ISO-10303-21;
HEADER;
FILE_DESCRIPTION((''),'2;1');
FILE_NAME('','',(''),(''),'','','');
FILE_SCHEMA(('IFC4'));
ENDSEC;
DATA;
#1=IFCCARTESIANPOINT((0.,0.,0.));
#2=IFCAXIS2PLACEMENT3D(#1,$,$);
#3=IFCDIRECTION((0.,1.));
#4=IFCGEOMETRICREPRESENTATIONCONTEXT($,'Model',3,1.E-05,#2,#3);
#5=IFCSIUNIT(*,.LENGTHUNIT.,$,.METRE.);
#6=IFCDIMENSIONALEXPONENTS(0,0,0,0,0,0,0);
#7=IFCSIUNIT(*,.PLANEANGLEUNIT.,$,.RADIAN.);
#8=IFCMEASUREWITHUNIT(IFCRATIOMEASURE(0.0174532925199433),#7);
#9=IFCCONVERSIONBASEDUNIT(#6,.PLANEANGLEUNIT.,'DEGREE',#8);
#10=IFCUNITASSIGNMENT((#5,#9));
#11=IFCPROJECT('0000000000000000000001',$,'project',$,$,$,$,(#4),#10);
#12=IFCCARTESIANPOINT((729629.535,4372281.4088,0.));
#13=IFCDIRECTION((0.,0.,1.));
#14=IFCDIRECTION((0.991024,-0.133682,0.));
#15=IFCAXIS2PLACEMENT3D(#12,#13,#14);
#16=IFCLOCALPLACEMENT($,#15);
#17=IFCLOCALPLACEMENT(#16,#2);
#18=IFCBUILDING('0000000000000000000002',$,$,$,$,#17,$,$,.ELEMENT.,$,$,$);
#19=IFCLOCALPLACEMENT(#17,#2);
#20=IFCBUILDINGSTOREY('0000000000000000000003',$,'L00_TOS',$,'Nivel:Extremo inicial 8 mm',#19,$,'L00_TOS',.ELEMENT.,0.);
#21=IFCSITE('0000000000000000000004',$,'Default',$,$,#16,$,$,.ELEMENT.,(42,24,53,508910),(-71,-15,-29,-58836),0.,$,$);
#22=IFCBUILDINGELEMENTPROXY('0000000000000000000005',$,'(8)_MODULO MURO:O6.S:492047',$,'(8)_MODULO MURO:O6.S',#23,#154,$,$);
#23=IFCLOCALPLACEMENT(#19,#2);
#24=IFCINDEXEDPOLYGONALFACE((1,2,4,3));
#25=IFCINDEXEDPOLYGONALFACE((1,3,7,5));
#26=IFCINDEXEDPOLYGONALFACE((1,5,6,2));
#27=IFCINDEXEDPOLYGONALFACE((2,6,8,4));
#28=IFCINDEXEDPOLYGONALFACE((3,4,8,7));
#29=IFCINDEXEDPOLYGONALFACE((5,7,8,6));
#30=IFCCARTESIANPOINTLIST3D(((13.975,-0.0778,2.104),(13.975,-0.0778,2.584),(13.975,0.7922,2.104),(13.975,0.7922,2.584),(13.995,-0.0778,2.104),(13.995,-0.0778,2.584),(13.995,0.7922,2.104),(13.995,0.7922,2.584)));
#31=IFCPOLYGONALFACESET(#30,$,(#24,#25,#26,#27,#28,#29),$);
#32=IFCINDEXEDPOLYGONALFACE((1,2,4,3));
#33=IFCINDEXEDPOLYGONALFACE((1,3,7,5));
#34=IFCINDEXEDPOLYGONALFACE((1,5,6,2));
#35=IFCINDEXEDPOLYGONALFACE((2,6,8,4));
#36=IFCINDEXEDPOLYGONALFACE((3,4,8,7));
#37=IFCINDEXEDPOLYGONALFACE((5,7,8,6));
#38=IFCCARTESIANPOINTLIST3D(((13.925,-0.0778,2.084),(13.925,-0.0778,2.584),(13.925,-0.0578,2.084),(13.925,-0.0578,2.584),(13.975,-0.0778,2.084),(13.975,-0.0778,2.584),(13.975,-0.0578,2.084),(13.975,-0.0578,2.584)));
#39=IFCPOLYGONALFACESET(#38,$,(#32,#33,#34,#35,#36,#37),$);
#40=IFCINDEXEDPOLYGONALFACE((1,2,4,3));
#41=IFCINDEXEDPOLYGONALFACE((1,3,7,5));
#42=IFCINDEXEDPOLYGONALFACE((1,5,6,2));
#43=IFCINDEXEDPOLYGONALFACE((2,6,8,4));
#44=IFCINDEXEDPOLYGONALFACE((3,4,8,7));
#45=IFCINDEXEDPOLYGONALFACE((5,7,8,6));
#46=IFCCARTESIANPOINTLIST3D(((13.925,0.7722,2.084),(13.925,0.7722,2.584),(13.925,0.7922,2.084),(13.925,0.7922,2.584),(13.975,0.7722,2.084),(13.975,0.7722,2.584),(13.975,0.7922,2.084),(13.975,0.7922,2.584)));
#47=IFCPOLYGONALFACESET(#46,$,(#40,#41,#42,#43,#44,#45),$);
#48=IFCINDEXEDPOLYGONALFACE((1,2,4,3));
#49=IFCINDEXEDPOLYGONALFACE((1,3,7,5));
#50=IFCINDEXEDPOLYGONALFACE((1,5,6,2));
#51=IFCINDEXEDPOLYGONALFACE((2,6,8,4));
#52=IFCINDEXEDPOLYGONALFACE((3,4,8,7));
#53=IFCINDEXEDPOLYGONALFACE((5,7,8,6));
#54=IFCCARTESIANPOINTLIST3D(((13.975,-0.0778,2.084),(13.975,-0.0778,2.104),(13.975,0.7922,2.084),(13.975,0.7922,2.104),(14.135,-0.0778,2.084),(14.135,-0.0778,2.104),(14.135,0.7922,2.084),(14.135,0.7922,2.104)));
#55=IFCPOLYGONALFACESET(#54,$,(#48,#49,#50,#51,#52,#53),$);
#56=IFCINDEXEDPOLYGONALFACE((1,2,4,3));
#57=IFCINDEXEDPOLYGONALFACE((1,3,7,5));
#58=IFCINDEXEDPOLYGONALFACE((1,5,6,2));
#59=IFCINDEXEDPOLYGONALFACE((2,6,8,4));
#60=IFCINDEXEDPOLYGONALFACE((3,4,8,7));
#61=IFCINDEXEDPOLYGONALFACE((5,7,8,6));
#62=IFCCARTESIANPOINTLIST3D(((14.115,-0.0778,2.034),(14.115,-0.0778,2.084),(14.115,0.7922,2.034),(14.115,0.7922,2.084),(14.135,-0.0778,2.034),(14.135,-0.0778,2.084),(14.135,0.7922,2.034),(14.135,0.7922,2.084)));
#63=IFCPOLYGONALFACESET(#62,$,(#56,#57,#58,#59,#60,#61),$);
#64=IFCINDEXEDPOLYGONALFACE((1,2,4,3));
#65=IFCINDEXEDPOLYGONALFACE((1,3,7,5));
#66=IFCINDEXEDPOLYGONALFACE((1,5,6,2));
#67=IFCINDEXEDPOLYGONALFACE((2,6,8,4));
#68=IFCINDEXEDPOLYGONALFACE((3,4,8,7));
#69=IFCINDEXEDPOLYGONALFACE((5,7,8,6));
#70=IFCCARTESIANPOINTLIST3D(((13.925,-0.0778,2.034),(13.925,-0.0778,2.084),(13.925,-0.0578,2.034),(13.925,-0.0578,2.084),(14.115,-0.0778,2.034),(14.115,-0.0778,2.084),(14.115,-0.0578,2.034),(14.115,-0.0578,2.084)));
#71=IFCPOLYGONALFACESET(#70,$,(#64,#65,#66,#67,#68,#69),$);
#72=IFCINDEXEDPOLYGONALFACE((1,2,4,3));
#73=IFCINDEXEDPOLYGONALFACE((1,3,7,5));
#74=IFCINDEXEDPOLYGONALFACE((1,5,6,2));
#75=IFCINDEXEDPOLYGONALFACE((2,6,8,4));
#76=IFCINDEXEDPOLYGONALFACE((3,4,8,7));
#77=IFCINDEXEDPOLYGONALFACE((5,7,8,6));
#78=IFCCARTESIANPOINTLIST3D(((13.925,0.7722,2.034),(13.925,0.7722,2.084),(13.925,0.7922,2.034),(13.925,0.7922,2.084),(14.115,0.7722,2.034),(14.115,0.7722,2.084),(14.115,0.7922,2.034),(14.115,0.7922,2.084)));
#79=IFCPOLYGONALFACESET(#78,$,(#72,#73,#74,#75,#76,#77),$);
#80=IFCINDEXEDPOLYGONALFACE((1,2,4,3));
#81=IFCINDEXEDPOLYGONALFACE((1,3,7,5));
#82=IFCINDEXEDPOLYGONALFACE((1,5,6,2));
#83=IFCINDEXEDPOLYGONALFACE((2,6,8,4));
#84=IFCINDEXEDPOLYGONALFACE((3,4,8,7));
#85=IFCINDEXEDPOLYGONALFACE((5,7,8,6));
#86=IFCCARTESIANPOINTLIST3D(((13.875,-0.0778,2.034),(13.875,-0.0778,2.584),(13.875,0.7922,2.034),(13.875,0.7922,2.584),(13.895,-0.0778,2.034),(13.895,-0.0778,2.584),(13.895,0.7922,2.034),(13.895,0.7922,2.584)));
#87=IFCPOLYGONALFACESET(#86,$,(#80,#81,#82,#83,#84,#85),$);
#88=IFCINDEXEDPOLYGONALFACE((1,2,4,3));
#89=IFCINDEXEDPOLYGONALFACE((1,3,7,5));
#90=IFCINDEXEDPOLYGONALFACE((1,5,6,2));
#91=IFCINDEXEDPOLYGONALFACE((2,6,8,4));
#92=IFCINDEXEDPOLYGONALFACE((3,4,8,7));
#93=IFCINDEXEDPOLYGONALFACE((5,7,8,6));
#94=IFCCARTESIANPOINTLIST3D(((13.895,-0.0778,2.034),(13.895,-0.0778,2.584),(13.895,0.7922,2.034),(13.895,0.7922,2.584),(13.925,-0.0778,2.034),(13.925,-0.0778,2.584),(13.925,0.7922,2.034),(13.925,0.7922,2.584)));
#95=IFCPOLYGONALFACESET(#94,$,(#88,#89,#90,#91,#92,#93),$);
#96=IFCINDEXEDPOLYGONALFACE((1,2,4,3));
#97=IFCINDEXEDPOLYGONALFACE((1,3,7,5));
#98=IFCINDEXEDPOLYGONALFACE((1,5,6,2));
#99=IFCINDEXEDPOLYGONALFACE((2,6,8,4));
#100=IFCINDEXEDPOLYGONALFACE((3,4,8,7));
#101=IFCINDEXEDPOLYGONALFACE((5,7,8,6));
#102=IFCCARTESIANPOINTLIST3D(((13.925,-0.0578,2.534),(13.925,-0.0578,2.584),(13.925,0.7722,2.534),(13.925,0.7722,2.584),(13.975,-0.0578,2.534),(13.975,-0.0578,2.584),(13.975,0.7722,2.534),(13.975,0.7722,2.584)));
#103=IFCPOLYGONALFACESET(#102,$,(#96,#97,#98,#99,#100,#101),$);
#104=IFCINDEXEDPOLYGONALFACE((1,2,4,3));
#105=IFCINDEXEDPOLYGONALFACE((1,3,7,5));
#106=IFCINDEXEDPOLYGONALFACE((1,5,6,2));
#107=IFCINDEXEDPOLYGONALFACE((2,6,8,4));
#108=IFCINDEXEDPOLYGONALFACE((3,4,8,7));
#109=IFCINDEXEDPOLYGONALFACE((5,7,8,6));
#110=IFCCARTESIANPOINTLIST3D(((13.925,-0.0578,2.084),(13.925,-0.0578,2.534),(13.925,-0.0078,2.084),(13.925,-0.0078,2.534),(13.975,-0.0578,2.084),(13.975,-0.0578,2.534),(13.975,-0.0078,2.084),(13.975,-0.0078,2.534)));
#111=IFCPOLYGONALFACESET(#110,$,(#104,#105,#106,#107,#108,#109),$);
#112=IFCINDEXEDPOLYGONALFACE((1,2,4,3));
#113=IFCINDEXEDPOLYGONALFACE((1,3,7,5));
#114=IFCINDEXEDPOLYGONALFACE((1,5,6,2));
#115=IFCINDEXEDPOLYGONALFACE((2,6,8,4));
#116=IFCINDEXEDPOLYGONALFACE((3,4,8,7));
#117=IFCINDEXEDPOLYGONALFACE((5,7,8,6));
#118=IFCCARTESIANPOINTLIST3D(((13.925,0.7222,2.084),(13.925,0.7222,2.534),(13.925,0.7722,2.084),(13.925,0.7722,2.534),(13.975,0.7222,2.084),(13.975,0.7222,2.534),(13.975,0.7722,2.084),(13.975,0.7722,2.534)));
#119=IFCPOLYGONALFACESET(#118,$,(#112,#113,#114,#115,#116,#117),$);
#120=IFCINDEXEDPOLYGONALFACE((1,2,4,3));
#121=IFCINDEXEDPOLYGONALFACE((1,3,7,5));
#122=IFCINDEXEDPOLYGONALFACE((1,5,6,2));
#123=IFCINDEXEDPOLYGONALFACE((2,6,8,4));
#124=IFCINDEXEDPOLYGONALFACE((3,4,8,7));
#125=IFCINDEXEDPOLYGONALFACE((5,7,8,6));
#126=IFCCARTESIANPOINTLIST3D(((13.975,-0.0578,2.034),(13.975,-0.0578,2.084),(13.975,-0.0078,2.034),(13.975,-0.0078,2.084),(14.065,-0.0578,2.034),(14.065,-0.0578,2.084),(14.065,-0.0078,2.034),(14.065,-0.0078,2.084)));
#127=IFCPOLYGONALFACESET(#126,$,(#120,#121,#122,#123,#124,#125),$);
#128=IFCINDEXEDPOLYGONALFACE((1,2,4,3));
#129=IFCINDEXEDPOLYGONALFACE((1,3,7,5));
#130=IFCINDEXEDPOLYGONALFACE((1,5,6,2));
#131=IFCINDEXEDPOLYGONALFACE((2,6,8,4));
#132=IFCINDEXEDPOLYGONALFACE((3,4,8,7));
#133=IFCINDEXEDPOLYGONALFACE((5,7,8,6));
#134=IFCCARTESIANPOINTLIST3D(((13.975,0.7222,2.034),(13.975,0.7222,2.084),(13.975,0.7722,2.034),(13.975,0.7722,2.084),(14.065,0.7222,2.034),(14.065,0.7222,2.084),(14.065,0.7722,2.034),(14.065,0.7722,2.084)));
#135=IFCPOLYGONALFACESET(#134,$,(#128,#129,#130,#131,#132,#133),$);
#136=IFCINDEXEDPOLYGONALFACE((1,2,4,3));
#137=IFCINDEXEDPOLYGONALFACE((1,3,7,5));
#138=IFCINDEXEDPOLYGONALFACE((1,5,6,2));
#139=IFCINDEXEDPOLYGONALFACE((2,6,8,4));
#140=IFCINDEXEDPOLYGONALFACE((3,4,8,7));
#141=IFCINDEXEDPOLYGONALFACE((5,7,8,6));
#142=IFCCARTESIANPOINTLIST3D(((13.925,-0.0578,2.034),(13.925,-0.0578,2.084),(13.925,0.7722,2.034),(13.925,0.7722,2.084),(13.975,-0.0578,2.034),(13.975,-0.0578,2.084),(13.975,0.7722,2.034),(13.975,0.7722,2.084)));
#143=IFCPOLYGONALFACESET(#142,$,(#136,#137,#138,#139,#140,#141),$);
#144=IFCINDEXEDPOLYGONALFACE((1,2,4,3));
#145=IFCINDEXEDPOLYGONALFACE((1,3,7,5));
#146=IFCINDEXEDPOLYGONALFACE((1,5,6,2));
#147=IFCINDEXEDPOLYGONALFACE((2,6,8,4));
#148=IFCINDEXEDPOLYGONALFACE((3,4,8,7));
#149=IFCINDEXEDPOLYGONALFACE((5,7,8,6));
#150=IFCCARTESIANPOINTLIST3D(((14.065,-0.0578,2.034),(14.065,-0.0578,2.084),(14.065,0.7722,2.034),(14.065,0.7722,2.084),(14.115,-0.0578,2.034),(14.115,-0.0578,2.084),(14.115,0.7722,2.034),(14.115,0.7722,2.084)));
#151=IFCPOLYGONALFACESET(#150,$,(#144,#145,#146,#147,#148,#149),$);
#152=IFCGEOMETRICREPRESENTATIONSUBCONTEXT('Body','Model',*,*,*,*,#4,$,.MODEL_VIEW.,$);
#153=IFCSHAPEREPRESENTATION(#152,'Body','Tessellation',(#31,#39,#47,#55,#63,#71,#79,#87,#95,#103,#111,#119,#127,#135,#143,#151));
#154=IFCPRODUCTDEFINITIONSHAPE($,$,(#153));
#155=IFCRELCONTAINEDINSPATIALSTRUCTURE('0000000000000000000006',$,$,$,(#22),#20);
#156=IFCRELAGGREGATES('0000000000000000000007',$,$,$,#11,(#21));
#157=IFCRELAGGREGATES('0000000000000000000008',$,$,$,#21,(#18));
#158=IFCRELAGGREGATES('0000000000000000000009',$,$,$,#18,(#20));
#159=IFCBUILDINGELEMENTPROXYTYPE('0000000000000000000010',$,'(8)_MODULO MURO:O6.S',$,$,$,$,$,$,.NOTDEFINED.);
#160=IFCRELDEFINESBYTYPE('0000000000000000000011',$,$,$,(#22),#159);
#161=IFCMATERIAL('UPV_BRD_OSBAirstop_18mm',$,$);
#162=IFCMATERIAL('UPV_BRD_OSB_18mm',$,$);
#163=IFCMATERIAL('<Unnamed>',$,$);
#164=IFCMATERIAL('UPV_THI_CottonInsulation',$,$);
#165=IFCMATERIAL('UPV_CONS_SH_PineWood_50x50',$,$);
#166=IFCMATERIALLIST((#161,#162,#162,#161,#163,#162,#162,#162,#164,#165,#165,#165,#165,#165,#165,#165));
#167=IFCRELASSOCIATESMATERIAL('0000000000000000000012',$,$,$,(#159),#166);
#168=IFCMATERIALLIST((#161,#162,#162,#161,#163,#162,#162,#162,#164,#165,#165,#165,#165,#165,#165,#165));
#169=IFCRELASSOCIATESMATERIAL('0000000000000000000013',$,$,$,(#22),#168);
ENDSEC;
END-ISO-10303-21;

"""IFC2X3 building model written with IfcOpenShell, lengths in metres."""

from ifc_helpers import new_model, entity, si_unit, converted_unit, direction, frame, frame_2d, origin, origin_2d_with_axis, place, context, subcontext, project, spatial, rectangle, extrude, source, transform, mapped, material, material_list, type_object, type_shapes, element, save


model = new_model("IFC2X3")

# Units and contexts
model_context = context("Model", 3, precision=1e-05, world=origin(), true_north=direction((0.0, 1.0)))
body_context = subcontext(model_context, "Body", "Model", "MODEL_VIEW")
ifc_project = project(units=[si_unit("LENGTHUNIT", "METRE"), converted_unit("PLANEANGLEUNIT", "DEGREE", entity("IfcRatioMeasure", 0.0174532925199433), si_unit("PLANEANGLEUNIT", "RADIAN"), dimensions=[0, 0, 0, 0, 0, 0, 0])], contexts=[model_context])

# Site, building, storey
site_placement = place(None, frame((729629.535, 4372281.4088, 0.0), z_axis=(0.0, 0.0, 1.0), x_axis=(0.991024, -0.133682, 0.0)))
site = spatial("IfcSite", under=ifc_project, at=site_placement, Name="Default", CompositionType="ELEMENT", RefLatitude=(42, 24, 53, 508910), RefLongitude=(-71, -15, -29, -58836), RefElevation=0.0)
building_placement = place(site_placement, origin())
building = spatial("IfcBuilding", under=site, at=building_placement, CompositionType="ELEMENT")
storey_placement = place(building_placement, origin())
storey = spatial("IfcBuildingStorey", under=building, at=storey_placement, Name="L00_TOS", ObjectType="Nivel:Extremo inicial 8 mm", LongName="L00_TOS", CompositionType="ELEMENT", Elevation=0.0)

# Building element proxy
ifc_material_1 = material(Name="UPV_BRD_OSBAirstop_18mm")
ifc_material_2 = material(Name="UPV_BRD_OSB_18mm")
ifc_material_3 = material(Name="UPV_THI_CottonInsulation")
ifc_material_4 = material(Name="<Unnamed>")
ifc_material_5 = material(Name="UPV_CONS_SH_PineWood_50x50")
ifc_material_list_1 = material_list([ifc_material_1, ifc_material_2, ifc_material_2, ifc_material_1, ifc_material_4, ifc_material_2, ifc_material_2, ifc_material_2, ifc_material_3, ifc_material_5, ifc_material_5, ifc_material_5, ifc_material_5, ifc_material_5, ifc_material_5, ifc_material_5])
ifc_material_list_2 = material_list([ifc_material_1, ifc_material_2, ifc_material_2, ifc_material_1, ifc_material_4, ifc_material_2, ifc_material_2, ifc_material_2, ifc_material_3, ifc_material_5, ifc_material_5, ifc_material_5, ifc_material_5, ifc_material_5, ifc_material_5, ifc_material_5])
building_element_proxy_type_1 = type_object("IfcBuildingElementProxyType", Name="(8)_MODULO MURO:O6.S", PredefinedType="NOTDEFINED", material=ifc_material_list_2)
shared_shape_1 = source(origin(), body_context, "Body", "SweptSolid", [
    extrude(rectangle(XDim=0.87, YDim=0.02, at=frame_2d((0.0, 0.0), x_axis=(1.0, 0.0))), frame((0.0, 0.035, 0.07), z_axis=(0.0, 0.0, 1.0), x_axis=(-1.0, 0.0, 0.0)), (0.0, 0.0, 1.0), 0.48),
    extrude(rectangle(XDim=0.05, YDim=0.02, at=frame_2d((0.0, 0.0), x_axis=(1.0, 0.0))), frame((-0.425, 0.07, 0.05), z_axis=(0.0, 0.0, 1.0), x_axis=(0.0, -1.0, 0.0)), (0.0, 0.0, 1.0), 0.5),
    extrude(rectangle(XDim=0.05, YDim=0.02, at=origin_2d_with_axis()), frame((0.425, 0.07, 0.05), z_axis=(0.0, 0.0, 1.0), x_axis=(0.0, -1.0, 0.0)), (0.0, 0.0, 1.0), 0.5),
    extrude(rectangle(XDim=0.87, YDim=0.16, at=origin_2d_with_axis()), frame((0.0, -0.035, 0.05)), (0.0, 0.0, 1.0), 0.02),
    extrude(rectangle(XDim=0.87, YDim=0.02, at=origin_2d_with_axis()), frame((0.0, -0.105, 0.0), z_axis=(0.0, 0.0, 1.0), x_axis=(-1.0, 0.0, 0.0)), (0.0, 0.0, 1.0), 0.05),
    extrude(rectangle(XDim=0.19, YDim=0.02, at=frame_2d((0.0, 0.0), x_axis=(1.0, 0.0))), frame((-0.425, 0.0, 0.0), z_axis=(0.0, 0.0, 1.0), x_axis=(0.0, -1.0, 0.0)), (0.0, 0.0, 1.0), 0.05),
    extrude(rectangle(XDim=0.19, YDim=0.02, at=origin_2d_with_axis()), frame((0.425, 0.0, 0.0), z_axis=(0.0, 0.0, 1.0), x_axis=(0.0, -1.0, 0.0)), (0.0, 0.0, 1.0), 0.05),
    extrude(rectangle(XDim=0.87, YDim=0.02, at=frame_2d((0.0, 0.0), x_axis=(1.0, 0.0))), frame((0.0, 0.135, 0.0), z_axis=(0.0, 0.0, 1.0), x_axis=(-1.0, 0.0, 0.0)), (0.0, 0.0, 1.0), 0.55),
    extrude(rectangle(XDim=0.87, YDim=0.03, at=origin_2d_with_axis()), frame((0.0, 0.11, 0.0)), (0.0, 0.0, 1.0), 0.55),
    extrude(rectangle(XDim=0.05, YDim=0.83, at=origin_2d_with_axis()), frame((0.0, 0.07, 0.5), z_axis=(0.0, 0.0, 1.0), x_axis=(0.0, -1.0, 0.0)), (0.0, 0.0, 1.0), 0.05),
    extrude(rectangle(XDim=0.05, YDim=0.05, at=origin_2d_with_axis()), frame((-0.39, 0.07, 0.05)), (0.0, 0.0, 1.0), 0.45),
    extrude(rectangle(XDim=0.05, YDim=0.05, at=origin_2d_with_axis()), frame((0.39, 0.07, 0.05), z_axis=(0.0, 0.0, 1.0), x_axis=(0.0, -1.0, 0.0)), (0.0, 0.0, 1.0), 0.45),
    extrude(rectangle(XDim=0.09, YDim=0.05, at=origin_2d_with_axis()), frame((-0.39, 0.0, 0.0), z_axis=(0.0, 0.0, 1.0), x_axis=(0.0, -1.0, 0.0)), (0.0, 0.0, 1.0), 0.05),
    extrude(rectangle(XDim=0.09, YDim=0.05, at=origin_2d_with_axis()), frame((0.39, 0.0, 0.0), z_axis=(0.0, 0.0, 1.0), x_axis=(0.0, -1.0, 0.0)), (0.0, 0.0, 1.0), 0.05),
    extrude(rectangle(XDim=0.05, YDim=0.83, at=origin_2d_with_axis()), frame((0.0, 0.07, 0.0), z_axis=(0.0, 0.0, 1.0), x_axis=(0.0, -1.0, 0.0)), (0.0, 0.0, 1.0), 0.05),
    extrude(rectangle(XDim=0.05, YDim=0.83, at=origin_2d_with_axis()), frame((0.0, -0.07, 0.0), z_axis=(0.0, 0.0, 1.0), x_axis=(0.0, -1.0, 0.0)), (0.0, 0.0, 1.0), 0.05),
])
type_shapes(building_element_proxy_type_1, [shared_shape_1])
proxy_1_placement = place(storey_placement, frame((14.02, 0.3572, 2.034), z_axis=(0.0, 0.0, 1.0), x_axis=(0.0, 1.0, 0.0)))
element("IfcBuildingElementProxy", 1, at=proxy_1_placement, inside=storey, type_object=building_element_proxy_type_1, material=ifc_material_list_1, Name="(8)_MODULO MURO:O6.S:492047", ObjectType="(8)_MODULO MURO:O6.S", context=body_context, shape_type="MappedRepresentation", body=[
    mapped(shared_shape_1, transform((0.0, 0.0, 0.0), scale=1.0)),
])

save(model, "model.ifc")
